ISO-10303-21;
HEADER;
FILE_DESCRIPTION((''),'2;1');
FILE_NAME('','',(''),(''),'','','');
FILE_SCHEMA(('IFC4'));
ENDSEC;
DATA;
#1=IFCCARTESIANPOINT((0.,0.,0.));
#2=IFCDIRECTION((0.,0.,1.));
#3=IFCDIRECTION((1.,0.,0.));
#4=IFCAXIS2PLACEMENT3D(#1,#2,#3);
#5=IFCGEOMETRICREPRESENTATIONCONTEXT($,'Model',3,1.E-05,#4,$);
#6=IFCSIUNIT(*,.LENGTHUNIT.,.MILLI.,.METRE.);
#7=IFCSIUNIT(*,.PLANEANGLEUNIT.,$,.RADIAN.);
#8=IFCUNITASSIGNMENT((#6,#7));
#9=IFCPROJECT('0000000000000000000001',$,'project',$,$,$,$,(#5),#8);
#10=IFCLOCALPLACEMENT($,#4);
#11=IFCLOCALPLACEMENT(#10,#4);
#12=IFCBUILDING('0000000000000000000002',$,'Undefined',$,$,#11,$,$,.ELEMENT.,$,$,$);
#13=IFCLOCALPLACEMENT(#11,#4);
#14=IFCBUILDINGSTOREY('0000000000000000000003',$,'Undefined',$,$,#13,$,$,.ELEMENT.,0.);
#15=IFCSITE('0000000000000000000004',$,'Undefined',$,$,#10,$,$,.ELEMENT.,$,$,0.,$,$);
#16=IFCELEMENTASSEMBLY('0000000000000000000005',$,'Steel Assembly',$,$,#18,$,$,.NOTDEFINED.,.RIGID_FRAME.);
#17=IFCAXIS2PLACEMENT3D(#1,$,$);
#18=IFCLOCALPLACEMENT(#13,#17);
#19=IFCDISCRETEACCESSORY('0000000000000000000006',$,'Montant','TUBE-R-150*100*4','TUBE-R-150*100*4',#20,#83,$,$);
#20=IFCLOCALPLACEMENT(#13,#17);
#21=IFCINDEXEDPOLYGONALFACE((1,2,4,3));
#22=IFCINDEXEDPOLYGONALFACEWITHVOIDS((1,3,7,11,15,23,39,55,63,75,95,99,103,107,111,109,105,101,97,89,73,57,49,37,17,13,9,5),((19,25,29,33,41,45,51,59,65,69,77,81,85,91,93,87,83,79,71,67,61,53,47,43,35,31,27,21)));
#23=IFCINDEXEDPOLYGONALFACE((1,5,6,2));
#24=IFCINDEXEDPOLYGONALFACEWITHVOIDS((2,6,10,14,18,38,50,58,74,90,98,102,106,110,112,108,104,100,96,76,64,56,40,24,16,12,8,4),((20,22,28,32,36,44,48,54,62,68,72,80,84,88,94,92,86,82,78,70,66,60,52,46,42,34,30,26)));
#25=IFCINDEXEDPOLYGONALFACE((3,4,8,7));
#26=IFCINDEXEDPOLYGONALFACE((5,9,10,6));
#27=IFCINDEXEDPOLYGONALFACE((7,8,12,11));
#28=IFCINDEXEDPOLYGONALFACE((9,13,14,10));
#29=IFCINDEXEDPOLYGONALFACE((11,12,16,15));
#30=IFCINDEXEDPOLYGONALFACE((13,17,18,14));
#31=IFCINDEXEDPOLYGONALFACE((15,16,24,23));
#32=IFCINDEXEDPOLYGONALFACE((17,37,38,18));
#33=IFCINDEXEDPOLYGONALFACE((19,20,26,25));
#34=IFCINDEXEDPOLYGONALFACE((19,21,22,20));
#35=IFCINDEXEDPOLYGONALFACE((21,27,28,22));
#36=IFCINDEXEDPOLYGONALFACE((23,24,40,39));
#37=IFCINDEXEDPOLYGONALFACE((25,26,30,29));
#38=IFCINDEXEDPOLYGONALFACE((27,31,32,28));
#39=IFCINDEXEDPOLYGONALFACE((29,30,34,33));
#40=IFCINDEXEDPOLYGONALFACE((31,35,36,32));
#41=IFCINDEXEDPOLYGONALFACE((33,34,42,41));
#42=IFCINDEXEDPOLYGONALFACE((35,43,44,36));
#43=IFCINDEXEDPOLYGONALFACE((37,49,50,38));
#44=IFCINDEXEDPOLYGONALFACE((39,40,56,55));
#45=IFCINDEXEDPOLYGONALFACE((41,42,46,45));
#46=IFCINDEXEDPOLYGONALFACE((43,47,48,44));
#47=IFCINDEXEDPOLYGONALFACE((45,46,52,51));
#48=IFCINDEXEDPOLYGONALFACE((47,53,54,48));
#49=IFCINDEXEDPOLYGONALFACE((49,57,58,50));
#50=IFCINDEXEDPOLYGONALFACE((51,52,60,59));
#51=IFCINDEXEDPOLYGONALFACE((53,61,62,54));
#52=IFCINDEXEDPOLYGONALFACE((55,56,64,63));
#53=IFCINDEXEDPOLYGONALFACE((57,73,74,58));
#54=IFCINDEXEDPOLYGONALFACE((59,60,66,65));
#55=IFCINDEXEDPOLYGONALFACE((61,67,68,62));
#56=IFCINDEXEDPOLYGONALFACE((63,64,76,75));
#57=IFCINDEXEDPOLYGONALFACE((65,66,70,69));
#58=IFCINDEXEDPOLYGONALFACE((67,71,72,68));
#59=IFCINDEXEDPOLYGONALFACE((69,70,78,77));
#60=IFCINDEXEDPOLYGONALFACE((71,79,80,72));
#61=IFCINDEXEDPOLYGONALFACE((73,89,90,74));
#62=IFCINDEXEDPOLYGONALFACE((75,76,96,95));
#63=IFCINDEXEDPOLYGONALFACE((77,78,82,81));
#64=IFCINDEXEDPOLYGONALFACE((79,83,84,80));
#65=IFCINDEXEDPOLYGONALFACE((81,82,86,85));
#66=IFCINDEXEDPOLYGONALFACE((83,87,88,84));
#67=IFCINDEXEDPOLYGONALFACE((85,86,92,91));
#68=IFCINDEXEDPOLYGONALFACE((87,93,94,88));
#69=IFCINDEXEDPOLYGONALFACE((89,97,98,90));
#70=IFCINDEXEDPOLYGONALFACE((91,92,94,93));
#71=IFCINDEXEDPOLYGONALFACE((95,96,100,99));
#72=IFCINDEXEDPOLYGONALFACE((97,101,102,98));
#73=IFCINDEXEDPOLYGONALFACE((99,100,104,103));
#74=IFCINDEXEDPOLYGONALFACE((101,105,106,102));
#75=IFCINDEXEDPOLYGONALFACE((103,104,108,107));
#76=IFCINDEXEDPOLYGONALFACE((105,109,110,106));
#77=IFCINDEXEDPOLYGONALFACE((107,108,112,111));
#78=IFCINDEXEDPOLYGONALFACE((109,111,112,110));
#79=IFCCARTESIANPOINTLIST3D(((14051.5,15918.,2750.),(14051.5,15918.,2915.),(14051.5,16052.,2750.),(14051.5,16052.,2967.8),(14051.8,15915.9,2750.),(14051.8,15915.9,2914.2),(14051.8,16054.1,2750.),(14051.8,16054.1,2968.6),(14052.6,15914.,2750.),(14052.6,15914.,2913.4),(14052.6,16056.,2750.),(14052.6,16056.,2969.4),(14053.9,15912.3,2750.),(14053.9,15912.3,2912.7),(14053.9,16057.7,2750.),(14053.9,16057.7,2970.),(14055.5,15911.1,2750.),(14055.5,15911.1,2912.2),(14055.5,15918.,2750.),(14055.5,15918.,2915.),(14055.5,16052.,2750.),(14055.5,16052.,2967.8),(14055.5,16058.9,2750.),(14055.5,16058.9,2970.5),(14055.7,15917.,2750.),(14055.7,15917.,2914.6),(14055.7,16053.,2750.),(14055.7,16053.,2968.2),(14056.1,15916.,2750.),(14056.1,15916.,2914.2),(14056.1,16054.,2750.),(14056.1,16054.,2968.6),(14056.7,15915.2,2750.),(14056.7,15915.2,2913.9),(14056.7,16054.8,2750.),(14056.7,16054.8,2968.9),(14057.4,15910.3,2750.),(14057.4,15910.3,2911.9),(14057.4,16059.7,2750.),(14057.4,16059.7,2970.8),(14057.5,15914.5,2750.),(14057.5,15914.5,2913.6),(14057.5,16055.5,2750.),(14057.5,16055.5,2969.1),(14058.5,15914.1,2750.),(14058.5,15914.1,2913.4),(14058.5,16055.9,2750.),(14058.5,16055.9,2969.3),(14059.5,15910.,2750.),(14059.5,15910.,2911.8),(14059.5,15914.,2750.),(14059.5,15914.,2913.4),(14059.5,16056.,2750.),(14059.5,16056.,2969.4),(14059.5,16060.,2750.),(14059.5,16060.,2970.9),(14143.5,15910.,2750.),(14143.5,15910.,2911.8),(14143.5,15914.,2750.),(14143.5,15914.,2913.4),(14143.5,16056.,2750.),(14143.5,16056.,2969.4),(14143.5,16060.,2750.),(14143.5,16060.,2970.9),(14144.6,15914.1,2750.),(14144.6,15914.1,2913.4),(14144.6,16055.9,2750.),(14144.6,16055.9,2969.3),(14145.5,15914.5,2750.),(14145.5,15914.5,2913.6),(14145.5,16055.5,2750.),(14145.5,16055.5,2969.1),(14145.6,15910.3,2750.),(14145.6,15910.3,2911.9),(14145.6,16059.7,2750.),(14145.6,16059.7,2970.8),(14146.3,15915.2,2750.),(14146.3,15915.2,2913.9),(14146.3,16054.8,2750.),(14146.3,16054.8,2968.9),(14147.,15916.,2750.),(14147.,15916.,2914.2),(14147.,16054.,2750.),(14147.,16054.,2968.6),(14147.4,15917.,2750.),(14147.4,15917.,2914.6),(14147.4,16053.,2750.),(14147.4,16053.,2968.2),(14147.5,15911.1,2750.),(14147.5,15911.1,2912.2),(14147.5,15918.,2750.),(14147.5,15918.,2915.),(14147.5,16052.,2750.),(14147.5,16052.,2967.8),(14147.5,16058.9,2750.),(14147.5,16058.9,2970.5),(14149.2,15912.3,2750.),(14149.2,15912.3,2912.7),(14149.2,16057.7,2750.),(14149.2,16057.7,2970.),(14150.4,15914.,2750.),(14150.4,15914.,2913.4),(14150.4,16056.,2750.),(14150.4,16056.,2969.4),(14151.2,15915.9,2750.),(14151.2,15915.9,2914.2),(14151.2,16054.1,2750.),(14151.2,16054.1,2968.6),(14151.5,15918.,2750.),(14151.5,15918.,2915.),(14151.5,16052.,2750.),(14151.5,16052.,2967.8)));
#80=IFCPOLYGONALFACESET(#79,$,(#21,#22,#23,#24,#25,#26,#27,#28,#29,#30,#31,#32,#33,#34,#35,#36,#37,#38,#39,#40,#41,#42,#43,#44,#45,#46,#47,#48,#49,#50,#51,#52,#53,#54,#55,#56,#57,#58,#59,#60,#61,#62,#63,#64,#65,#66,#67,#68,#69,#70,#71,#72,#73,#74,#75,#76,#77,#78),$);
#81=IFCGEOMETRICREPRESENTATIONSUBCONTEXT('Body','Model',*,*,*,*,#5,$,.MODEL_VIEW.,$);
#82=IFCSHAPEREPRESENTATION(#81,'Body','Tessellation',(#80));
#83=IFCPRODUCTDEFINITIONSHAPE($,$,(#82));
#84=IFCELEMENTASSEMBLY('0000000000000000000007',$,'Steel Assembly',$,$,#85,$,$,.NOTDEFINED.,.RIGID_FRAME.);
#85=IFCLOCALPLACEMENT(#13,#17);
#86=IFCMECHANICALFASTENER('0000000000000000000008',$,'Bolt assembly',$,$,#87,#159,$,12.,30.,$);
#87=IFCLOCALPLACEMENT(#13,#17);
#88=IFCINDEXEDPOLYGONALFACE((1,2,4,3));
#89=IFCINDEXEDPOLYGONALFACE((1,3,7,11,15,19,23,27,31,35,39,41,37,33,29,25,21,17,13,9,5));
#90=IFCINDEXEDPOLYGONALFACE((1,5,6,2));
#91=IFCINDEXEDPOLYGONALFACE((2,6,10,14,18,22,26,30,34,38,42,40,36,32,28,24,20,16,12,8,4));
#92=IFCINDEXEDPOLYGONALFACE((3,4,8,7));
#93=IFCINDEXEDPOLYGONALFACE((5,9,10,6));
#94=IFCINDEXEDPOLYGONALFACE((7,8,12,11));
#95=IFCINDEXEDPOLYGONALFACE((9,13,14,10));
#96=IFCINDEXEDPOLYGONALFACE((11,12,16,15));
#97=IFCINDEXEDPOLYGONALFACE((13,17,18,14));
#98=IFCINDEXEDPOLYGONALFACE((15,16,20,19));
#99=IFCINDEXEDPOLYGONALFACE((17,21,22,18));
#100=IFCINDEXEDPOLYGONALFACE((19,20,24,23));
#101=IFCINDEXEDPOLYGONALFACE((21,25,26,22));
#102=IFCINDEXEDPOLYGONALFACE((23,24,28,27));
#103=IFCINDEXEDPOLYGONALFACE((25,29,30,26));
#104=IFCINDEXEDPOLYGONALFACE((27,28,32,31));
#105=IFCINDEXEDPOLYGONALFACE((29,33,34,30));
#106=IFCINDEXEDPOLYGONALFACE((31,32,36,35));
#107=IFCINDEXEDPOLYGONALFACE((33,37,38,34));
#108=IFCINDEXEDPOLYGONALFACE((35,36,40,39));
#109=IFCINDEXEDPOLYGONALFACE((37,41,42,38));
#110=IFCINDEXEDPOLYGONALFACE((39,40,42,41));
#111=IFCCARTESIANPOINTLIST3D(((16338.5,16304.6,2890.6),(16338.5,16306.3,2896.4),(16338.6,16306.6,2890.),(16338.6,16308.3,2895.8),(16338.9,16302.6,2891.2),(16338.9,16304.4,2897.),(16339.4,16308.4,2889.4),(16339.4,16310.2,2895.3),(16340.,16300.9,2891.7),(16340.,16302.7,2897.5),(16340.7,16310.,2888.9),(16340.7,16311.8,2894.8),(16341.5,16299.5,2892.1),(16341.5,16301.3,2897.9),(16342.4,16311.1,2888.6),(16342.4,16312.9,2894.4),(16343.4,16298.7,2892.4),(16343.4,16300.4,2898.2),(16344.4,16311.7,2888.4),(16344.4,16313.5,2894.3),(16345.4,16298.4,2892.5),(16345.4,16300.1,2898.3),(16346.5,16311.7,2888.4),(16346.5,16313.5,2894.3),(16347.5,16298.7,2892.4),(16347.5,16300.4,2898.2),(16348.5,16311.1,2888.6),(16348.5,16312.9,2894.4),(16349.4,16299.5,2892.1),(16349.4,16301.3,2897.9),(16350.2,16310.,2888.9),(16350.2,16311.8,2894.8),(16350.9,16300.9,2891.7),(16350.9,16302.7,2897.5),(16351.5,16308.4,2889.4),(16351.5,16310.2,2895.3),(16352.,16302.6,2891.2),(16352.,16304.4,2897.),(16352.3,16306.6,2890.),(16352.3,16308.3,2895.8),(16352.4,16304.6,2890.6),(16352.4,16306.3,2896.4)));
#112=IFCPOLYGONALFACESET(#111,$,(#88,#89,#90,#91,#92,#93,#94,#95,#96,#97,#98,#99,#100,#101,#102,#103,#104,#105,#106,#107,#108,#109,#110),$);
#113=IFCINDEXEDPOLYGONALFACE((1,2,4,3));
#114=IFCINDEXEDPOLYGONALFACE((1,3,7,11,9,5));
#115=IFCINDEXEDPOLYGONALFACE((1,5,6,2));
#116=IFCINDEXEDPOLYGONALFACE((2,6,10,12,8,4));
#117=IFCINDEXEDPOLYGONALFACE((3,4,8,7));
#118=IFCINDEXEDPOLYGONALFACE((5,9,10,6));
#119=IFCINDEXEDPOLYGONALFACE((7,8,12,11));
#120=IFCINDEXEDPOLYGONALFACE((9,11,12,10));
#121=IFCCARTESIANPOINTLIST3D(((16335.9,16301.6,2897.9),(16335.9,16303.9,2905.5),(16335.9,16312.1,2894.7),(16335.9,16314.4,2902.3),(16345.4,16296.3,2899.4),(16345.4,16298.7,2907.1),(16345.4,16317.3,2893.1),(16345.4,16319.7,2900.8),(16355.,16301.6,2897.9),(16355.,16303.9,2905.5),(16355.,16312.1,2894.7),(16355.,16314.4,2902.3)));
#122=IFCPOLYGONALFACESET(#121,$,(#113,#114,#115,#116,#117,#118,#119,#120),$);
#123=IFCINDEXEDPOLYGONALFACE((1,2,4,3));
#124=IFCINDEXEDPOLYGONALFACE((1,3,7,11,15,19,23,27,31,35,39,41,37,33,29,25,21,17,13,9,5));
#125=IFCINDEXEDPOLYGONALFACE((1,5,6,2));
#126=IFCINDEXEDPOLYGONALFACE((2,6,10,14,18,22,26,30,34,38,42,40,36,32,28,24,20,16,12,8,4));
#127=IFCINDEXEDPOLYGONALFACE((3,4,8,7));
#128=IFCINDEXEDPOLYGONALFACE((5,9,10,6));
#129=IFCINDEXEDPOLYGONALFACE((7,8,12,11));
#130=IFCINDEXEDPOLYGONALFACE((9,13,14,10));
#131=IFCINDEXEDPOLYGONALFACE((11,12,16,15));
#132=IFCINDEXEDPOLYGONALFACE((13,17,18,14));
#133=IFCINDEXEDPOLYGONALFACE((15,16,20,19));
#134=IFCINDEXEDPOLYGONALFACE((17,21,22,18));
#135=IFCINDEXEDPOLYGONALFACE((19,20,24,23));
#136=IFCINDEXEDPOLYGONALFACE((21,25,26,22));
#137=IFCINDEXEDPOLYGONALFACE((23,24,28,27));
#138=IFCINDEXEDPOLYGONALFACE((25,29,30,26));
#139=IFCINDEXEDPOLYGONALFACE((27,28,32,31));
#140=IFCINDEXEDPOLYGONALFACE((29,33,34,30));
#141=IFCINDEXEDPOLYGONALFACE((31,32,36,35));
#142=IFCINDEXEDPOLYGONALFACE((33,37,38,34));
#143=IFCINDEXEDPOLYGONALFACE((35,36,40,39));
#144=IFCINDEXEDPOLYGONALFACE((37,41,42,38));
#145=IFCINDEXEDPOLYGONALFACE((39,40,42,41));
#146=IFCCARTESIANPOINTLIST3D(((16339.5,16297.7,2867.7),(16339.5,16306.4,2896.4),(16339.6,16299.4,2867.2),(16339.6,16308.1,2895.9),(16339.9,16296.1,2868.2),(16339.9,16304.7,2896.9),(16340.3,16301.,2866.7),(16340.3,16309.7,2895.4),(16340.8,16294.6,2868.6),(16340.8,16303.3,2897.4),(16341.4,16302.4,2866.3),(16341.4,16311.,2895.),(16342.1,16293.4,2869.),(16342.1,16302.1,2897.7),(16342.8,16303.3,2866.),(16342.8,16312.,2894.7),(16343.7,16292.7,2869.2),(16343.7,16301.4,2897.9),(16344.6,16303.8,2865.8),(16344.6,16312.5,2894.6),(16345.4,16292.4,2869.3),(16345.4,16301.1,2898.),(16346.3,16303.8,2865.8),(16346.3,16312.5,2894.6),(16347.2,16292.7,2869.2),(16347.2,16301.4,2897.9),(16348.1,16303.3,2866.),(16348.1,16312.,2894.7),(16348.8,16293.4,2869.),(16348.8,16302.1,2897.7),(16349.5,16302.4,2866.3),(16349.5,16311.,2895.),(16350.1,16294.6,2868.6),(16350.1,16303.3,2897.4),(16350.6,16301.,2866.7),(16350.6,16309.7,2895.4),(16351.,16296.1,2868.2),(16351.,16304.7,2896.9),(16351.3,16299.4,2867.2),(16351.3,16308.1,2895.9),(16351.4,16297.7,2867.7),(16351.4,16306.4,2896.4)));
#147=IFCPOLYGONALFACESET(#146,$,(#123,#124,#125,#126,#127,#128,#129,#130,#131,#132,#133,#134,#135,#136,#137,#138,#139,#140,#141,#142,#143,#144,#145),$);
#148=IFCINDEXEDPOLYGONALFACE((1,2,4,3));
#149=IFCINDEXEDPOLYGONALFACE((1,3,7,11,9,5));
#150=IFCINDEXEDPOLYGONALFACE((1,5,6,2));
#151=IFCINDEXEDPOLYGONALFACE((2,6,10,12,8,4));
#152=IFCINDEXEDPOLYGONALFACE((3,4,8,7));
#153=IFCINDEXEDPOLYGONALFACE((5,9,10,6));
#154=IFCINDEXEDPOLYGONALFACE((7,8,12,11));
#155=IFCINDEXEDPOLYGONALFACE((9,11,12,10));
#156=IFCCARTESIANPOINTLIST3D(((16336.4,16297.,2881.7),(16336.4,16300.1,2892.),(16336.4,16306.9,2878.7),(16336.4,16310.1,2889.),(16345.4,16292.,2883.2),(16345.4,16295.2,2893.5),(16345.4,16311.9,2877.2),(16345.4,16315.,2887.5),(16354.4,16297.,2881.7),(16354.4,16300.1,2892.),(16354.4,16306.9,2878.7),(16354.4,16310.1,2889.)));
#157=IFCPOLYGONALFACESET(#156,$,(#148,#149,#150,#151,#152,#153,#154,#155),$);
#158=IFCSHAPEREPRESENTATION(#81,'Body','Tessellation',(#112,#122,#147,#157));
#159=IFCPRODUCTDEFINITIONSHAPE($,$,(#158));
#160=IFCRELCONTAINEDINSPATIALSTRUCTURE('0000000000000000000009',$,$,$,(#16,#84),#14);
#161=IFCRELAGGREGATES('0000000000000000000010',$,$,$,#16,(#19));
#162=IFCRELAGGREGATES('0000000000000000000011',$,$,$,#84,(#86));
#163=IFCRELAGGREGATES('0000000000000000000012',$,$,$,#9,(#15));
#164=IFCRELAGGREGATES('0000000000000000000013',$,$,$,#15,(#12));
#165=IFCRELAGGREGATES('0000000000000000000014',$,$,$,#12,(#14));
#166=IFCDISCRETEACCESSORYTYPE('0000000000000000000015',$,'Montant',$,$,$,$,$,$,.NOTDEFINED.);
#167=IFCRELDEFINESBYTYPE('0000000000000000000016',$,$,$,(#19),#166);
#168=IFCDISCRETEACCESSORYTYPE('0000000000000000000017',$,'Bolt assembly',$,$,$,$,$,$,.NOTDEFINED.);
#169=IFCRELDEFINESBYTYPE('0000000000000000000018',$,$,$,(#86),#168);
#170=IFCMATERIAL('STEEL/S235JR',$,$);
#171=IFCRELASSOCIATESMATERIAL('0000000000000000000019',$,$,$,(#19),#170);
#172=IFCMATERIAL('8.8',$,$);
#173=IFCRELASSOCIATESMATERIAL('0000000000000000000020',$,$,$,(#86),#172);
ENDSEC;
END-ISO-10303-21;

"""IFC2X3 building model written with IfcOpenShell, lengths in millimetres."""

from ifc_helpers import new_model, si_unit, frame, origin_with_axes, origin_2d_with_axis, place, context, subcontext, project, spatial, polyline, hollow_rectangle, circle, outline, extrude, clip, halfspace, source, transform, mapped, material, type_object, element, aggregate, save


model = new_model("IFC2X3")

# Units and contexts
model_context = context("Model", 3, precision=1e-05, world=origin_with_axes())
body_context = subcontext(model_context, "Body", "Model", "MODEL_VIEW")
ifc_project = project(units=[si_unit("LENGTHUNIT", "METRE", prefix="MILLI"), si_unit("PLANEANGLEUNIT", "RADIAN")], contexts=[model_context])

# Site, building, storey
site_placement = place(None, origin_with_axes())
site = spatial("IfcSite", under=ifc_project, at=site_placement, Name="Undefined", CompositionType="ELEMENT", RefElevation=0.0)
building_placement = place(site_placement, origin_with_axes())
building = spatial("IfcBuilding", under=site, at=building_placement, Name="Undefined", CompositionType="ELEMENT")
storey_placement = place(building_placement, origin_with_axes())
storey = spatial("IfcBuildingStorey", under=building, at=storey_placement, Name="Undefined", CompositionType="ELEMENT", Elevation=0.0)

# Shared definitions
ifc_material_1 = material(Name="STEEL/S235JR")

# Element assembly
assembly_1_placement = place(storey_placement, origin_with_axes())
assembly_1 = element("IfcElementAssembly", 1, at=assembly_1_placement, inside=storey, Name="Steel Assembly", AssemblyPlace="NOTDEFINED", PredefinedType="RIGID_FRAME")
discrete_accessory_type_1 = type_object("IfcDiscreteAccessoryType", Name="Bolt assembly")

# Shared definitions
ifc_material_2 = material(Name="8.8")

# Discrete accessory
discrete_accessory_type_2 = type_object("IfcDiscreteAccessoryType", Name="Montant")
discrete_accessory_1_placement = place(assembly_1_placement, frame((14101.5, 15985.0, 3075.7), z_axis=(0.0, 1.0, 0.0), x_axis=(0.0, 0.0, -1.0)))
discrete_accessory_1 = element("IfcDiscreteAccessory", 2, at=discrete_accessory_1_placement, type_object=discrete_accessory_type_2, material=ifc_material_1, Name="Montant", Description="TUBE-R-150*100*4", ObjectType="TUBE-R-150*100*4", context=body_context, shape_type="Clipping", body=[
    clip(extrude(hollow_rectangle(XDim=100.0, YDim=150.0, WallThickness=4.0, InnerFilletRadius=4.0, OuterFilletRadius=8.0, at=origin_2d_with_axis()), frame((325.7, 0.0, 0.0), z_axis=(-1.0, 0.0, 0.0), x_axis=(0.0, -1.0, 0.0)), (0.0, 0.0, 1.0), 221.2), halfspace(frame((163.9, -50.0, -75.0), z_axis=(0.930375, 0.0, 0.366608), x_axis=(0.0, -1.0, 0.0)), True)),
])
aggregate(assembly_1, [discrete_accessory_1])

# Element assembly, mechanical fastener
assembly_2_placement = place(storey_placement, origin_with_axes())
assembly_2 = element("IfcElementAssembly", 3, at=assembly_2_placement, inside=storey, Name="Steel Assembly", AssemblyPlace="NOTDEFINED", PredefinedType="RIGID_FRAME")
shared_shape_1 = source(origin_with_axes(), body_context, "Body", "SweptSolid", [
    extrude(circle(Radius=7.0, at=origin_2d_with_axis()), frame((0.0, -6.0, 0.0), z_axis=(0.0, 1.0, 0.0), x_axis=(1.0, 0.0, 0.0)), (0.0, 0.0, 1.0), 6.1),
    extrude(outline(polyline([(11.0, 0.0), (5.5, 9.5), (-5.5, 9.5), (-11.0, 0.0), (-5.5, -9.5), (5.5, -9.5), (11.0, 0.0)])), frame((0.0, -14.0, 0.0), z_axis=(0.0, 1.0, 0.0), x_axis=(1.0, 0.0, 0.0)), (0.0, 0.0, 1.0), 8.0),
    extrude(circle(Radius=6.0, at=origin_2d_with_axis()), frame((0.0, -6.0, 0.0), z_axis=(0.0, 1.0, 0.0), x_axis=(1.0, 0.0, 0.0)), (0.0, 0.0, 1.0), 30.0),
    extrude(outline(polyline([(10.4, 0.0), (5.2, 9.0), (-5.2, 9.0), (-10.4, 0.0), (-5.2, -9.0), (5.2, -9.0), (10.4, 0.0)])), frame((0.0, 0.0, 0.0), z_axis=(0.0, 1.0, 0.0), x_axis=(1.0, 0.0, 0.0)), (0.0, 0.0, 1.0), 10.8),
])
mechanical_fastener_1_placement = place(assembly_2_placement, frame((16345.5, 16305.1, 2890.5), z_axis=(1.0, 0.0, 0.0), x_axis=(0.0, -0.957179, 0.289497)))
mechanical_fastener_1 = element("IfcMechanicalFastener", 4, at=mechanical_fastener_1_placement, type_object=discrete_accessory_type_1, material=ifc_material_2, Name="Bolt assembly", NominalDiameter=12.0, NominalLength=30.0, context=body_context, shape_type="MappedRepresentation", body=[
    mapped(shared_shape_1, transform((0.0, 0.0, 0.0))),
])
aggregate(assembly_2, [mechanical_fastener_1])

save(model, "model.ifc")
